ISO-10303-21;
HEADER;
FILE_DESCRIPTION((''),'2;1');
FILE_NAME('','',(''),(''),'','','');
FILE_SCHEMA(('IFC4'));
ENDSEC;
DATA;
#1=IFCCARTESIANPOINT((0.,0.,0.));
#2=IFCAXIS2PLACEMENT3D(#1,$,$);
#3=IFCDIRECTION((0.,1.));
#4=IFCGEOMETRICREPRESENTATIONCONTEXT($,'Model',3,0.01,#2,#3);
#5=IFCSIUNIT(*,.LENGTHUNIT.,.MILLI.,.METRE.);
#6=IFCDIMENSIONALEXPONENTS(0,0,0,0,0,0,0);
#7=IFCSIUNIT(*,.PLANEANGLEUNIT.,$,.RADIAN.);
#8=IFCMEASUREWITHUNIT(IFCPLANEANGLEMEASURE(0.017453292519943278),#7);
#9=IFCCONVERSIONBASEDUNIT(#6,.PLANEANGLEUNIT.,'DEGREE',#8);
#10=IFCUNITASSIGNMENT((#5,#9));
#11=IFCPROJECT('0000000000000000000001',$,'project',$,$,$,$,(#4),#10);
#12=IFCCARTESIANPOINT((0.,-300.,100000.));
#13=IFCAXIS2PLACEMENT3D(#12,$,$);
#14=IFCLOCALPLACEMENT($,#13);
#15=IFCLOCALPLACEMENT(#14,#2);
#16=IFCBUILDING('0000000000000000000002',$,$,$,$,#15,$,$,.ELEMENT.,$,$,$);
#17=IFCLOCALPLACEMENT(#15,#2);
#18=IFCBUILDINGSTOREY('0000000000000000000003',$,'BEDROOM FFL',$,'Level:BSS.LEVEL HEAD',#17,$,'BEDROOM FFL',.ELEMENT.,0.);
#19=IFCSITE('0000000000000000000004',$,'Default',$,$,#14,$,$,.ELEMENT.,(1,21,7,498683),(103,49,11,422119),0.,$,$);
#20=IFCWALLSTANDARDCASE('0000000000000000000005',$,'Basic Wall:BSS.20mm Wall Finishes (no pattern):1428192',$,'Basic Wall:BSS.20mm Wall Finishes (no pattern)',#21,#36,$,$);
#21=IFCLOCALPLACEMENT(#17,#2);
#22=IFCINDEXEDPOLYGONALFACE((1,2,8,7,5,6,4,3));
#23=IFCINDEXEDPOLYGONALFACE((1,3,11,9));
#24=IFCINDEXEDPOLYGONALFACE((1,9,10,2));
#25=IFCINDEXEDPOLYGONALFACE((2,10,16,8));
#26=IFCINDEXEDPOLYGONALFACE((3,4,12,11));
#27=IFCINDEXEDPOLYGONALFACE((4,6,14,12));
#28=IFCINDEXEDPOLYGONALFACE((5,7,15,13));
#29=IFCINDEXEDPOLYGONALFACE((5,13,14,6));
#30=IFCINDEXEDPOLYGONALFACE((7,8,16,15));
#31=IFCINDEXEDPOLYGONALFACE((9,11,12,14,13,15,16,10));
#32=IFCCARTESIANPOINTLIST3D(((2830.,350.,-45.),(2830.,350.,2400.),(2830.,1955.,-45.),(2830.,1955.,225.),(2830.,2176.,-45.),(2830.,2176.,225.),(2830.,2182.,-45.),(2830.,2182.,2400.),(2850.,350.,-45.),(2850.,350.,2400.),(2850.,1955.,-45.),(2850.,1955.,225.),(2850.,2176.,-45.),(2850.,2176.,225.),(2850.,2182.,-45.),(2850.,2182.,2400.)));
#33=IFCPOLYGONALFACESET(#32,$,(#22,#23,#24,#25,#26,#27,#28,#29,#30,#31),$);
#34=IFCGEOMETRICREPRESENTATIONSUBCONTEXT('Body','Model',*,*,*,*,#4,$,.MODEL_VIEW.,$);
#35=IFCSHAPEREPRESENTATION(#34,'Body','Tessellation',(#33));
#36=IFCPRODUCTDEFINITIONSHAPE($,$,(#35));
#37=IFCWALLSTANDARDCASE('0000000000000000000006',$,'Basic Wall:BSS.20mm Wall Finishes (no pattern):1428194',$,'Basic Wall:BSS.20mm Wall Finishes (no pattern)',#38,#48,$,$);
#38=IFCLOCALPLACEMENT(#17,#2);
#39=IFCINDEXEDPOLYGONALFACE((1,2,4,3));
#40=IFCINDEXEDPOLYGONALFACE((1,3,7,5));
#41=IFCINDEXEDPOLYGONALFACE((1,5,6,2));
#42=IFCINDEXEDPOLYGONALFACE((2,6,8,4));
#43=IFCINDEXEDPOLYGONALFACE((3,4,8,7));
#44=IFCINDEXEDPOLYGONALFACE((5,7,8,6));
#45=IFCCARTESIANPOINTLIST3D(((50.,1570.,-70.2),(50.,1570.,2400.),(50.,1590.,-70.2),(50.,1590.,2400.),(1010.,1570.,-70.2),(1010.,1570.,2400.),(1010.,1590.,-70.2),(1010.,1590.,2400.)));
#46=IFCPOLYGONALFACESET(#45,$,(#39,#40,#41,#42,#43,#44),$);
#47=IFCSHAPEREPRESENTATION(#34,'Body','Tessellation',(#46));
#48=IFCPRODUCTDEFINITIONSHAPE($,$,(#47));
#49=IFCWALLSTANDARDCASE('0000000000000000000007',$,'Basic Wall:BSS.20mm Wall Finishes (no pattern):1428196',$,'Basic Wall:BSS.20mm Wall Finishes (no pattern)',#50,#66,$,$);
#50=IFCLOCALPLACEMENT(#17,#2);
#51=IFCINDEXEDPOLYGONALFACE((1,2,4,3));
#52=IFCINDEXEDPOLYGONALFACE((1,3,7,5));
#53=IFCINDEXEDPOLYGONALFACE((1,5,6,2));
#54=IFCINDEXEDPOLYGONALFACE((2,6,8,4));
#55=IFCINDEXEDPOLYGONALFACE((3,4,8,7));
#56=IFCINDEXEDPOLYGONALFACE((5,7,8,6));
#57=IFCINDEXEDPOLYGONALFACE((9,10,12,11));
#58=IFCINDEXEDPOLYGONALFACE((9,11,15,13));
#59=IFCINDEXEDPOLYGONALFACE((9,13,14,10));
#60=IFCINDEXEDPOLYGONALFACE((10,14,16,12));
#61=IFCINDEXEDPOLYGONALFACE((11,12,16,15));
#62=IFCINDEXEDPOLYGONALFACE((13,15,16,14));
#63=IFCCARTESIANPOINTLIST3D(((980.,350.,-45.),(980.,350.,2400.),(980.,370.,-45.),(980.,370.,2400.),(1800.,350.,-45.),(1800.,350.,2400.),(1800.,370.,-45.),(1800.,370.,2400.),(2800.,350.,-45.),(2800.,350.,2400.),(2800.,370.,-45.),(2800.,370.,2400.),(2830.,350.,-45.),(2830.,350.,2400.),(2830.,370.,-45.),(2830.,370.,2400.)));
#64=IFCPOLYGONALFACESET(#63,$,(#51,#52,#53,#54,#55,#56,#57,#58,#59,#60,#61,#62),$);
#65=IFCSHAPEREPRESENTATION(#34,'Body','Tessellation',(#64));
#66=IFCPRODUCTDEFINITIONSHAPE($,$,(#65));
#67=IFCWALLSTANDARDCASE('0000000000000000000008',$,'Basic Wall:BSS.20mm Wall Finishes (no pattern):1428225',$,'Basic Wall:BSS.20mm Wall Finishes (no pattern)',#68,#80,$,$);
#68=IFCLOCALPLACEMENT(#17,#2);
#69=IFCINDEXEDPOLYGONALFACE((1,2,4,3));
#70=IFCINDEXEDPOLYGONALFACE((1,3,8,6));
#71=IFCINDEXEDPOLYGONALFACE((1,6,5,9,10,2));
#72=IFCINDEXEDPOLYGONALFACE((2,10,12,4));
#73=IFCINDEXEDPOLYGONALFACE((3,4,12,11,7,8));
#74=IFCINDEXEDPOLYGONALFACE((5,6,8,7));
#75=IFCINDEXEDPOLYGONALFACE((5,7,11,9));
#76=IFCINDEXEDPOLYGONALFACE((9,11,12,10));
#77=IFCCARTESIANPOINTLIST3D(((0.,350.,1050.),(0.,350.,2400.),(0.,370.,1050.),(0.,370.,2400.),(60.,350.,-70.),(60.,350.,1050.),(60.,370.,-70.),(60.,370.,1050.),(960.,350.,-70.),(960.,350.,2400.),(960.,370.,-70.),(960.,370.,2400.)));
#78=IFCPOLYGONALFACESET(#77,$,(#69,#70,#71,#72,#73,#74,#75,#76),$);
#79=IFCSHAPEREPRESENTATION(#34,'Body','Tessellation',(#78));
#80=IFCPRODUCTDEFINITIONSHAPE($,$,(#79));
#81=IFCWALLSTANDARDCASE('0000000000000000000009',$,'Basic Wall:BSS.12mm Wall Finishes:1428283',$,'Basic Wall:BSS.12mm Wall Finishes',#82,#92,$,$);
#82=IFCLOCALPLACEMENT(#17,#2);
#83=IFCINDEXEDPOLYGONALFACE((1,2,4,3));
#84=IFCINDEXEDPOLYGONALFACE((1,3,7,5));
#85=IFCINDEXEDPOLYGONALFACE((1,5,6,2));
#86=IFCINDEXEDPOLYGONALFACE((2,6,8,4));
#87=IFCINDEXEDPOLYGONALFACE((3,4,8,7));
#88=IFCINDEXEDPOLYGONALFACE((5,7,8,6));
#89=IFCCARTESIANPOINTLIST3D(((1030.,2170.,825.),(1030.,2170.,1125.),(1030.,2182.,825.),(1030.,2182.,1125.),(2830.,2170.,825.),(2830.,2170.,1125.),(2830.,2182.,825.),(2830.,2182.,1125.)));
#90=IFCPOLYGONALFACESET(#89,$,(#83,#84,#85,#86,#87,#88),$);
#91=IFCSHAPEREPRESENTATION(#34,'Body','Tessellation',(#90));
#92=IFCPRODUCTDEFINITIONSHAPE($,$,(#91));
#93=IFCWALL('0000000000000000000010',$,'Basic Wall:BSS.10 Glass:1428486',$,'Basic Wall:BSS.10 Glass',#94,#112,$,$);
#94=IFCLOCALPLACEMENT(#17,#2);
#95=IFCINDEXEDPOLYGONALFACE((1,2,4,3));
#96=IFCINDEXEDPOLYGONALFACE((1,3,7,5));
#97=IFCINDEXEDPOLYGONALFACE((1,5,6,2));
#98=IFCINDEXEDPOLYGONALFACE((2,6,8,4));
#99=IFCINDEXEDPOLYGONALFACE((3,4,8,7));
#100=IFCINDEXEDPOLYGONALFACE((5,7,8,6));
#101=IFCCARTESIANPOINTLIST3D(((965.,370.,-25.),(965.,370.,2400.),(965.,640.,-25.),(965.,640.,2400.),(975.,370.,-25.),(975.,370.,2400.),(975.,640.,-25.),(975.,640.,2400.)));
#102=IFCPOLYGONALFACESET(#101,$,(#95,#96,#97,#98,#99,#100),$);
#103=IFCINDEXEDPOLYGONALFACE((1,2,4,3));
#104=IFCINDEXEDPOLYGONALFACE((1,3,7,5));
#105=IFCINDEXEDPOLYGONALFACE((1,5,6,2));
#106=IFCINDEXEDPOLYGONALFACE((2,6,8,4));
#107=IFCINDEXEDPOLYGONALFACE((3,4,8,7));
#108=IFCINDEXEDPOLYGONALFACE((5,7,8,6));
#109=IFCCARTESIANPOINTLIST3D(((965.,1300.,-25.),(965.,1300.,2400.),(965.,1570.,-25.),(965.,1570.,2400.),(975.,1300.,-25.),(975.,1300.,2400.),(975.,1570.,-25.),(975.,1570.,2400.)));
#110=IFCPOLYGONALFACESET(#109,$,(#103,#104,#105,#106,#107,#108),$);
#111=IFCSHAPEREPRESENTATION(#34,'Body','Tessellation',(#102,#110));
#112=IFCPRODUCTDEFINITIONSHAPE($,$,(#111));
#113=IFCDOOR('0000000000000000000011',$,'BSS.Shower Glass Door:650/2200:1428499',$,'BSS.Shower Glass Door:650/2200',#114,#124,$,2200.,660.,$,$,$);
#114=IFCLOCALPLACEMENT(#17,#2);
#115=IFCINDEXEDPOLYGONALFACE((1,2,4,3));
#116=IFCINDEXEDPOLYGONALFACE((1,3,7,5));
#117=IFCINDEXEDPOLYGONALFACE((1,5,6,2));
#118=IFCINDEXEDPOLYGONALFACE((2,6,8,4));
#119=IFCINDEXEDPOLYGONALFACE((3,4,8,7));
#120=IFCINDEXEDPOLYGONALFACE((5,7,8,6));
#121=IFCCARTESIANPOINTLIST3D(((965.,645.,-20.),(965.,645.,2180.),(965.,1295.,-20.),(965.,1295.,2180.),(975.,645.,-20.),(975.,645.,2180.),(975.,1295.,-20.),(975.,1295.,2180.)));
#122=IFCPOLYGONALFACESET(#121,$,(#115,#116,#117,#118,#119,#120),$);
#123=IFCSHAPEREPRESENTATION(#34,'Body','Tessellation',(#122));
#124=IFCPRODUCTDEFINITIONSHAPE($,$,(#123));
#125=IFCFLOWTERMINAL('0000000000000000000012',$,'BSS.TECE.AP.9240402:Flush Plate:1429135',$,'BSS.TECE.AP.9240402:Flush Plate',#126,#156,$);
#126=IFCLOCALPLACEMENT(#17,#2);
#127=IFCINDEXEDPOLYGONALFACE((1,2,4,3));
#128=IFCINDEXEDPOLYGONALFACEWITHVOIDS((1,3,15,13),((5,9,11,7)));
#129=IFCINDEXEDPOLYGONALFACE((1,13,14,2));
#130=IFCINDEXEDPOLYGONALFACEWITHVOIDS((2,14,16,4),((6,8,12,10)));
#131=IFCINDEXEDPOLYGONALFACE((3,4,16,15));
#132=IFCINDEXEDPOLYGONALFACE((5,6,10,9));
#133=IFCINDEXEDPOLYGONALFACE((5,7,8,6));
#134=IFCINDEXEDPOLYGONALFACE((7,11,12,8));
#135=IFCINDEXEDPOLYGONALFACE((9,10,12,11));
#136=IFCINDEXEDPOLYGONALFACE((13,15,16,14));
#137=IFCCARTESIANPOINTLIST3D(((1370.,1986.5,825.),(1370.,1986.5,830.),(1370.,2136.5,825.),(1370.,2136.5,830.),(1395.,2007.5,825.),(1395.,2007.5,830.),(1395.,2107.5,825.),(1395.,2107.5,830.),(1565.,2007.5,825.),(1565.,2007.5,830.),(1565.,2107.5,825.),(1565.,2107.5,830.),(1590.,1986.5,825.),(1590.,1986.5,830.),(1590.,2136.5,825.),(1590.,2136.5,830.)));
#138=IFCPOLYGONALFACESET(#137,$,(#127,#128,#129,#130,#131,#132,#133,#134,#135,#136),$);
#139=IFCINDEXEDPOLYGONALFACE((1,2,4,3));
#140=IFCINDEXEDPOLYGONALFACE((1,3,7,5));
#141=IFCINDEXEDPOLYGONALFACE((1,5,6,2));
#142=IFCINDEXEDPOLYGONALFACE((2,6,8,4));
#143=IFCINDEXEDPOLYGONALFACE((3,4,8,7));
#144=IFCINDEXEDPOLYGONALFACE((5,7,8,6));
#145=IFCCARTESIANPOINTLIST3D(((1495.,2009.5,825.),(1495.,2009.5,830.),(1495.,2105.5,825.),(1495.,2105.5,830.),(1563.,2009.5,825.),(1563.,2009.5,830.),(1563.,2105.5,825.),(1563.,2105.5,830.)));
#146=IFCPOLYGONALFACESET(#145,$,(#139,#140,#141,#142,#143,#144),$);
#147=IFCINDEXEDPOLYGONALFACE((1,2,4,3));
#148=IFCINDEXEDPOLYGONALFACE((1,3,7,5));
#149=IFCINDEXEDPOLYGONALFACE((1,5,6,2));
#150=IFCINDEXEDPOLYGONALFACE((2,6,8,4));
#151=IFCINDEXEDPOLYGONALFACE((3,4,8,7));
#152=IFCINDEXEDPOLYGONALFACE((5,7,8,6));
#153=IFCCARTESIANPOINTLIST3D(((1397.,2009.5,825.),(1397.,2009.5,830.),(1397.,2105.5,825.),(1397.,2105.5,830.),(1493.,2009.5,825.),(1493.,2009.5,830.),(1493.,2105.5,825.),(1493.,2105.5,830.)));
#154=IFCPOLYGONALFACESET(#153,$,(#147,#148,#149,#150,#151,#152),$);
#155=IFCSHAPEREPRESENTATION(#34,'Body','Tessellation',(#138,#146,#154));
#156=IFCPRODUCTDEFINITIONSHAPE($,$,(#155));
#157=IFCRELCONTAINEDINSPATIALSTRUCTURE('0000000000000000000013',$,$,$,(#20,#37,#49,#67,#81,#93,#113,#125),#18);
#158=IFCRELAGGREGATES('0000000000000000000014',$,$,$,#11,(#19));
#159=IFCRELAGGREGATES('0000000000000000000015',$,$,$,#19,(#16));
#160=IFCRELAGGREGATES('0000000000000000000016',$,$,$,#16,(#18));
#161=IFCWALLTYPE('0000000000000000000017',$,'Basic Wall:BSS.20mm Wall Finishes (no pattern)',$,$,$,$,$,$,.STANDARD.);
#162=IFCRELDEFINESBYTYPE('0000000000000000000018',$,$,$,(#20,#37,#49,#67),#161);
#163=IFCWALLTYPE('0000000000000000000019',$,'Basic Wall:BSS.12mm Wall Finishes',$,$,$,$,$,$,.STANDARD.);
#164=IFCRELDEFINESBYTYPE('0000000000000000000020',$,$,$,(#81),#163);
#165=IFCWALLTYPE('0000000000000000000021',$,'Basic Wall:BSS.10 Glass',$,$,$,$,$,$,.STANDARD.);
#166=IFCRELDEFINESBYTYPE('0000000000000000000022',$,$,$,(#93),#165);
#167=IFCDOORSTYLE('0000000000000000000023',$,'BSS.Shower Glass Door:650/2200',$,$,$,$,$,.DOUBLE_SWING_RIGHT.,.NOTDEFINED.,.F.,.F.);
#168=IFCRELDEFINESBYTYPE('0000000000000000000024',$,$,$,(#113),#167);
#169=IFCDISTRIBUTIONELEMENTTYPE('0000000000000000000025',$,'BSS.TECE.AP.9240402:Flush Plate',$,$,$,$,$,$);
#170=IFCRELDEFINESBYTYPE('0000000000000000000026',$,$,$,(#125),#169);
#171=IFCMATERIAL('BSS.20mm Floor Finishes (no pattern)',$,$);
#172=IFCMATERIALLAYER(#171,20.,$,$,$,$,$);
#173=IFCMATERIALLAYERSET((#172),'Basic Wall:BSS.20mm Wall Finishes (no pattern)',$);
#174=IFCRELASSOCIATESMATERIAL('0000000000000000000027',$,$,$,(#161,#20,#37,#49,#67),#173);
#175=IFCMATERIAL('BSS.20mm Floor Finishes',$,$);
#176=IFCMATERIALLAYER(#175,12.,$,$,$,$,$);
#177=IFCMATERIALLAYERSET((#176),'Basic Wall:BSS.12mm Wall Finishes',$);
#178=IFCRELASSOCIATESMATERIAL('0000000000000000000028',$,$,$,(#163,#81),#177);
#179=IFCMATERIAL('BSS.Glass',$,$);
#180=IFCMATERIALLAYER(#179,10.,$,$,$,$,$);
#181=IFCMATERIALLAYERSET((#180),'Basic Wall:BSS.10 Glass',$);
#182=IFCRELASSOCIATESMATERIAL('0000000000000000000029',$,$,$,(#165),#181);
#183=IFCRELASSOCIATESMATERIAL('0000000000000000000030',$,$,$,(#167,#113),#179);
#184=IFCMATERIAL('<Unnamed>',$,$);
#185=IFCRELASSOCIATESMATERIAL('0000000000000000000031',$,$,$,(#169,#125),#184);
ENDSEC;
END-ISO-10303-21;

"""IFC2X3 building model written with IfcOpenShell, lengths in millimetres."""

from ifc_helpers import new_model, entity, si_unit, converted_unit, direction, frame, frame_2d, origin, origin_2d_with_axis, place, context, subcontext, project, spatial, polyline, rectangle, outline, extrude, clip, halfspace, source, transform, mapped, material, layer, layer_set, layer_usage, type_object, type_shapes, element, fill, save


model = new_model("IFC2X3")

# Units and contexts
model_context = context("Model", 3, precision=0.01, world=origin(), true_north=direction((0.0, 1.0)))
body_context = subcontext(model_context, "Body", "Model", "MODEL_VIEW")
ifc_project = project(units=[si_unit("LENGTHUNIT", "METRE", prefix="MILLI"), converted_unit("PLANEANGLEUNIT", "DEGREE", entity("IfcPlaneAngleMeasure", 0.017453292519943278), si_unit("PLANEANGLEUNIT", "RADIAN"), dimensions=[0, 0, 0, 0, 0, 0, 0])], contexts=[model_context])

# Site, building, storey
site_placement = place(None, frame((0.0, -300.0, 100000.0)))
site = spatial("IfcSite", under=ifc_project, at=site_placement, Name="Default", CompositionType="ELEMENT", RefLatitude=(1, 21, 7, 498683), RefLongitude=(103, 49, 11, 422119), RefElevation=0.0)
building_placement = place(site_placement, origin())
building = spatial("IfcBuilding", under=site, at=building_placement, CompositionType="ELEMENT")
storey_placement = place(building_placement, origin())
storey = spatial("IfcBuildingStorey", under=building, at=storey_placement, Name="BEDROOM FFL", ObjectType="Level:BSS.LEVEL HEAD", LongName="BEDROOM FFL", CompositionType="ELEMENT", Elevation=0.0)

# Shared definitions
ifc_material_1 = material(Name="BSS.20mm Floor Finishes (no pattern)")

# Wall, opening
ifc_layer_1 = layer(ifc_material_1, 20.0)
ifc_layer_set_1 = layer_set([ifc_layer_1], Name="Basic Wall:BSS.20mm Wall Finishes (no pattern)")
ifc_layer_usage_1 = layer_usage(ifc_layer_set_1, "AXIS2", "POSITIVE", -10.0)
wall_type_1 = type_object("IfcWallType", Name="Basic Wall:BSS.20mm Wall Finishes (no pattern)", PredefinedType="STANDARD", material=ifc_layer_set_1)
wall_1_placement = place(storey_placement, frame((2840.0, 350.0, -45.0), z_axis=(0.0, 0.0, 1.0), x_axis=(0.0, 1.0, 0.0)))
wall_1 = element("IfcWallStandardCase", 1, at=wall_1_placement, inside=storey, type_object=wall_type_1, material=ifc_layer_usage_1, Name="Basic Wall:BSS.20mm Wall Finishes (no pattern):1428192", ObjectType="Basic Wall:BSS.20mm Wall Finishes (no pattern)", context=body_context, shape_type="SweptSolid", body=[
    extrude(rectangle(XDim=1832.0, YDim=20.0, at=frame_2d((916.0, 0.0), x_axis=(-1.0, 0.0))), origin(), (0.0, 0.0, 1.0), 2445.0),
])
opening_1_placement = place(wall_1_placement, origin())
element("IfcOpeningElement", 2, at=opening_1_placement, cuts=wall_1, ObjectType="Opening", context=body_context, shape_type="SweptSolid", body=[
    extrude(rectangle(XDim=270.0, YDim=221.0, at=frame_2d((0.0, 0.0), x_axis=(0.0, 1.0))), frame((1715.5, 10.0, 135.0), z_axis=(0.0, -1.0, 0.0), x_axis=(1.0, 0.0, 0.0)), (0.0, 0.0, 1.0), 20.0),
])

# Wall
ifc_layer_usage_2 = layer_usage(ifc_layer_set_1, "AXIS2", "POSITIVE", -10.0)
wall_2_placement = place(storey_placement, frame((1010.0, 1580.0, -70.2), z_axis=(0.0, 0.0, 1.0), x_axis=(-1.0, 0.0, 0.0)))
element("IfcWallStandardCase", 3, at=wall_2_placement, inside=storey, type_object=wall_type_1, material=ifc_layer_usage_2, Name="Basic Wall:BSS.20mm Wall Finishes (no pattern):1428194", ObjectType="Basic Wall:BSS.20mm Wall Finishes (no pattern)", context=body_context, shape_type="SweptSolid", body=[
    extrude(rectangle(XDim=960.0, YDim=20.0, at=frame_2d((480.0, 0.0), x_axis=(-1.0, 0.0))), origin(), (0.0, 0.0, 1.0), 2470.2),
])

# Wall, opening
ifc_layer_usage_3 = layer_usage(ifc_layer_set_1, "AXIS2", "POSITIVE", -10.0)
wall_3_placement = place(storey_placement, frame((980.0, 360.0, -45.0)))
wall_3 = element("IfcWallStandardCase", 4, at=wall_3_placement, inside=storey, type_object=wall_type_1, material=ifc_layer_usage_3, Name="Basic Wall:BSS.20mm Wall Finishes (no pattern):1428196", ObjectType="Basic Wall:BSS.20mm Wall Finishes (no pattern)", context=body_context, shape_type="SweptSolid", body=[
    extrude(rectangle(XDim=1850.0, YDim=20.0, at=frame_2d((925.0, 0.0), x_axis=(-1.0, 0.0))), origin(), (0.0, 0.0, 1.0), 2445.0),
])
opening_2_placement = place(wall_3_placement, frame((-980.0, -360.0, 45.0)))
element("IfcOpeningElement", 5, at=opening_2_placement, cuts=wall_3, ObjectType="Opening", context=body_context, shape_type="SweptSolid", body=[
    extrude(rectangle(XDim=2445.0, YDim=1000.0, at=frame_2d((0.0, 0.0), x_axis=(1.0, 0.0))), frame((2300.0, -1174.0, 1177.5), z_axis=(0.0, 1.0, 0.0), x_axis=(0.0, 0.0, -1.0)), (0.0, 0.0, 1.0), 3048.0),
])

# Wall, openings
ifc_layer_usage_4 = layer_usage(ifc_layer_set_1, "AXIS2", "POSITIVE", -10.0)
wall_4_placement = place(storey_placement, frame((960.0, 360.0, -70.0), z_axis=(0.0, 0.0, 1.0), x_axis=(-1.0, 0.0, 0.0)))
wall_4 = element("IfcWallStandardCase", 6, at=wall_4_placement, inside=storey, type_object=wall_type_1, material=ifc_layer_usage_4, Name="Basic Wall:BSS.20mm Wall Finishes (no pattern):1428225", ObjectType="Basic Wall:BSS.20mm Wall Finishes (no pattern)", context=body_context, shape_type="SweptSolid", body=[
    extrude(rectangle(XDim=960.0, YDim=20.0, at=frame_2d((480.0, 0.0), x_axis=(-1.0, 0.0))), origin(), (0.0, 0.0, 1.0), 2470.0),
])
opening_3_placement = place(wall_4_placement, origin())
element("IfcOpeningElement", 7, at=opening_3_placement, cuts=wall_4, ObjectType="Opening", context=body_context, shape_type="SweptSolid", body=[
    extrude(rectangle(XDim=1350.0, YDim=20.0, at=frame_2d((0.0, 0.0), x_axis=(0.0, 1.0))), frame((900.0, -710.0, 1795.0), z_axis=(0.0, 1.0, 0.0), x_axis=(-1.0, 0.0, 0.0)), (0.0, 0.0, 1.0), 700.0),
])
opening_4_placement = place(wall_4_placement, origin())
element("IfcOpeningElement", 8, at=opening_4_placement, cuts=wall_4, ObjectType="Opening", context=body_context, shape_type="SweptSolid", body=[
    extrude(rectangle(XDim=1120.0, YDim=60.0, at=frame_2d((0.0, 0.0), x_axis=(0.0, 1.0))), frame((930.0, 10.0, 560.0), z_axis=(0.0, -1.0, 0.0), x_axis=(1.0, 0.0, 0.0)), (0.0, 0.0, 1.0), 20.0),
])

# Wall
ifc_material_2 = material(Name="BSS.20mm Floor Finishes")
ifc_layer_2 = layer(ifc_material_2, 12.0)
ifc_layer_set_2 = layer_set([ifc_layer_2], Name="Basic Wall:BSS.12mm Wall Finishes")
ifc_layer_usage_5 = layer_usage(ifc_layer_set_2, "AXIS2", "POSITIVE", -6.0)
wall_type_2 = type_object("IfcWallType", Name="Basic Wall:BSS.12mm Wall Finishes", PredefinedType="STANDARD", material=ifc_layer_set_2)
wall_5_placement = place(storey_placement, frame((2830.0, 2176.0, 825.0), z_axis=(0.0, 0.0, 1.0), x_axis=(-1.0, 0.0, 0.0)))
element("IfcWallStandardCase", 9, at=wall_5_placement, inside=storey, type_object=wall_type_2, material=ifc_layer_usage_5, Name="Basic Wall:BSS.12mm Wall Finishes:1428283", ObjectType="Basic Wall:BSS.12mm Wall Finishes", context=body_context, shape_type="Clipping", body=[
    clip(extrude(rectangle(XDim=1800.0, YDim=12.0, at=frame_2d((900.0, 0.0), x_axis=(-1.0, 0.0))), origin(), (0.0, 0.0, 1.0), 300.0), halfspace(frame((0.0, -6.0, 300.0), z_axis=(0.0, 0.0, 1.0), x_axis=(0.0, 1.0, 0.0)), False)),
])

# Wall, opening, door
ifc_material_3 = material(Name="BSS.Glass")
ifc_layer_3 = layer(ifc_material_3, 10.0)
ifc_layer_set_3 = layer_set([ifc_layer_3], Name="Basic Wall:BSS.10 Glass")
wall_type_3 = type_object("IfcWallType", Name="Basic Wall:BSS.10 Glass", PredefinedType="STANDARD", material=ifc_layer_set_3)
wall_6_placement = place(storey_placement, frame((970.0, 370.0, -25.0), z_axis=(0.0, 0.0, 1.0), x_axis=(0.0, 1.0, 0.0)))
wall_6 = element("IfcWall", 10, at=wall_6_placement, inside=storey, type_object=wall_type_3, Name="Basic Wall:BSS.10 Glass:1428486", ObjectType="Basic Wall:BSS.10 Glass", context=body_context, shape_type="SweptSolid", body=[
    extrude(rectangle(XDim=270.0, YDim=10.0, at=origin_2d_with_axis()), frame((135.0, 0.0, 0.0)), (0.0, 0.0, 1.0), 2425.0),
    extrude(rectangle(XDim=270.0, YDim=10.0, at=frame_2d((0.0, 0.0), x_axis=(1.0, 0.0))), frame((1065.0, 0.0, 0.0), z_axis=(0.0, 0.0, 1.0), x_axis=(-1.0, 0.0, 0.0)), (0.0, 0.0, 1.0), 2425.0),
])
opening_5_placement = place(wall_6_placement, frame((930.0, 5.0, 5.0)))
opening_5 = element("IfcOpeningElement", 11, at=opening_5_placement, cuts=wall_6, ObjectType="Opening", context=body_context, shape_type="SweptSolid", body=[
    extrude(rectangle(XDim=660.0, YDim=2200.0, at=frame_2d((1100.0, 330.0), x_axis=(0.0, 1.0))), frame((0.0, 0.0, 0.0), z_axis=(0.0, -1.0, 0.0), x_axis=(0.0, 0.0, 1.0)), (0.0, 0.0, 1.0), 10.0),
])
door_style = type_object("IfcDoorStyle", Name="BSS.Shower Glass Door:650/2200", ConstructionType="NOTDEFINED", OperationType="DOUBLE_SWING_RIGHT", ParameterTakesPrecedence=False, Sizeable=False, material=ifc_material_3)
shared_shape_1 = source(origin(), body_context, "Body", "SweptSolid", [
    extrude(rectangle(XDim=650.0, YDim=10.0, at=origin_2d_with_axis()), frame((330.0, 5.0, 0.0), z_axis=(0.0, 0.0, 1.0), x_axis=(-1.0, 0.0, 0.0)), (0.0, 0.0, 1.0), 2200.0),
])
type_shapes(door_style, [shared_shape_1])
door_placement = place(opening_5_placement, frame((0.0, 0.0, 0.0), z_axis=(0.0, 0.0, 1.0), x_axis=(-1.0, 0.0, 0.0)))
door = element("IfcDoor", 12, at=door_placement, inside=storey, type_object=door_style, material=ifc_material_3, Name="BSS.Shower Glass Door:650/2200:1428499", ObjectType="BSS.Shower Glass Door:650/2200", OverallHeight=2200.0, OverallWidth=660.0, context=body_context, shape_type="MappedRepresentation", body=[
    mapped(shared_shape_1, transform((0.0, 0.0, 0.0), scale=1.0)),
])
fill(opening_5, door)

# Flow terminal
ifc_material_4 = material(Name="<Unnamed>")
distribution_element_type = type_object("IfcDistributionElementType", Name="BSS.TECE.AP.9240402:Flush Plate", material=ifc_material_4)
shared_shape_2 = source(origin(), body_context, "Body", "SweptSolid", [
    extrude(outline(polyline([(-110.0, -75.0), (110.0, -75.0), (110.0, 75.0), (-110.0, 75.0), (-110.0, -75.0)]), holes=[polyline([(-85.0, -46.0), (-85.0, 54.0), (85.0, 54.0), (85.0, -46.0), (-85.0, -46.0)])]), frame((0.0, 0.0, 0.0), z_axis=(0.0, 0.0, 1.0), x_axis=(-1.0, 0.0, 0.0)), (0.0, 0.0, 1.0), 5.0),
    extrude(rectangle(XDim=68.0, YDim=96.0, at=frame_2d((0.0, 0.0), x_axis=(1.0, 0.0))), frame((49.0, -4.0, 0.0)), (0.0, 0.0, 1.0), 5.0),
    extrude(rectangle(XDim=96.0, YDim=96.0, at=frame_2d((0.0, 0.0), x_axis=(1.0, 0.0))), frame((-35.0, -4.0, 0.0)), (0.0, 0.0, 1.0), 5.0),
])
type_shapes(distribution_element_type, [shared_shape_2])
flow_terminal_placement = place(storey_placement, frame((1480.0, 2061.5, 825.0)))
element("IfcFlowTerminal", 13, at=flow_terminal_placement, inside=storey, type_object=distribution_element_type, material=ifc_material_4, Name="BSS.TECE.AP.9240402:Flush Plate:1429135", ObjectType="BSS.TECE.AP.9240402:Flush Plate", context=body_context, shape_type="MappedRepresentation", body=[
    mapped(shared_shape_2, transform((0.0, 0.0, 0.0), scale=1.0)),
])

save(model, "model.ifc")
